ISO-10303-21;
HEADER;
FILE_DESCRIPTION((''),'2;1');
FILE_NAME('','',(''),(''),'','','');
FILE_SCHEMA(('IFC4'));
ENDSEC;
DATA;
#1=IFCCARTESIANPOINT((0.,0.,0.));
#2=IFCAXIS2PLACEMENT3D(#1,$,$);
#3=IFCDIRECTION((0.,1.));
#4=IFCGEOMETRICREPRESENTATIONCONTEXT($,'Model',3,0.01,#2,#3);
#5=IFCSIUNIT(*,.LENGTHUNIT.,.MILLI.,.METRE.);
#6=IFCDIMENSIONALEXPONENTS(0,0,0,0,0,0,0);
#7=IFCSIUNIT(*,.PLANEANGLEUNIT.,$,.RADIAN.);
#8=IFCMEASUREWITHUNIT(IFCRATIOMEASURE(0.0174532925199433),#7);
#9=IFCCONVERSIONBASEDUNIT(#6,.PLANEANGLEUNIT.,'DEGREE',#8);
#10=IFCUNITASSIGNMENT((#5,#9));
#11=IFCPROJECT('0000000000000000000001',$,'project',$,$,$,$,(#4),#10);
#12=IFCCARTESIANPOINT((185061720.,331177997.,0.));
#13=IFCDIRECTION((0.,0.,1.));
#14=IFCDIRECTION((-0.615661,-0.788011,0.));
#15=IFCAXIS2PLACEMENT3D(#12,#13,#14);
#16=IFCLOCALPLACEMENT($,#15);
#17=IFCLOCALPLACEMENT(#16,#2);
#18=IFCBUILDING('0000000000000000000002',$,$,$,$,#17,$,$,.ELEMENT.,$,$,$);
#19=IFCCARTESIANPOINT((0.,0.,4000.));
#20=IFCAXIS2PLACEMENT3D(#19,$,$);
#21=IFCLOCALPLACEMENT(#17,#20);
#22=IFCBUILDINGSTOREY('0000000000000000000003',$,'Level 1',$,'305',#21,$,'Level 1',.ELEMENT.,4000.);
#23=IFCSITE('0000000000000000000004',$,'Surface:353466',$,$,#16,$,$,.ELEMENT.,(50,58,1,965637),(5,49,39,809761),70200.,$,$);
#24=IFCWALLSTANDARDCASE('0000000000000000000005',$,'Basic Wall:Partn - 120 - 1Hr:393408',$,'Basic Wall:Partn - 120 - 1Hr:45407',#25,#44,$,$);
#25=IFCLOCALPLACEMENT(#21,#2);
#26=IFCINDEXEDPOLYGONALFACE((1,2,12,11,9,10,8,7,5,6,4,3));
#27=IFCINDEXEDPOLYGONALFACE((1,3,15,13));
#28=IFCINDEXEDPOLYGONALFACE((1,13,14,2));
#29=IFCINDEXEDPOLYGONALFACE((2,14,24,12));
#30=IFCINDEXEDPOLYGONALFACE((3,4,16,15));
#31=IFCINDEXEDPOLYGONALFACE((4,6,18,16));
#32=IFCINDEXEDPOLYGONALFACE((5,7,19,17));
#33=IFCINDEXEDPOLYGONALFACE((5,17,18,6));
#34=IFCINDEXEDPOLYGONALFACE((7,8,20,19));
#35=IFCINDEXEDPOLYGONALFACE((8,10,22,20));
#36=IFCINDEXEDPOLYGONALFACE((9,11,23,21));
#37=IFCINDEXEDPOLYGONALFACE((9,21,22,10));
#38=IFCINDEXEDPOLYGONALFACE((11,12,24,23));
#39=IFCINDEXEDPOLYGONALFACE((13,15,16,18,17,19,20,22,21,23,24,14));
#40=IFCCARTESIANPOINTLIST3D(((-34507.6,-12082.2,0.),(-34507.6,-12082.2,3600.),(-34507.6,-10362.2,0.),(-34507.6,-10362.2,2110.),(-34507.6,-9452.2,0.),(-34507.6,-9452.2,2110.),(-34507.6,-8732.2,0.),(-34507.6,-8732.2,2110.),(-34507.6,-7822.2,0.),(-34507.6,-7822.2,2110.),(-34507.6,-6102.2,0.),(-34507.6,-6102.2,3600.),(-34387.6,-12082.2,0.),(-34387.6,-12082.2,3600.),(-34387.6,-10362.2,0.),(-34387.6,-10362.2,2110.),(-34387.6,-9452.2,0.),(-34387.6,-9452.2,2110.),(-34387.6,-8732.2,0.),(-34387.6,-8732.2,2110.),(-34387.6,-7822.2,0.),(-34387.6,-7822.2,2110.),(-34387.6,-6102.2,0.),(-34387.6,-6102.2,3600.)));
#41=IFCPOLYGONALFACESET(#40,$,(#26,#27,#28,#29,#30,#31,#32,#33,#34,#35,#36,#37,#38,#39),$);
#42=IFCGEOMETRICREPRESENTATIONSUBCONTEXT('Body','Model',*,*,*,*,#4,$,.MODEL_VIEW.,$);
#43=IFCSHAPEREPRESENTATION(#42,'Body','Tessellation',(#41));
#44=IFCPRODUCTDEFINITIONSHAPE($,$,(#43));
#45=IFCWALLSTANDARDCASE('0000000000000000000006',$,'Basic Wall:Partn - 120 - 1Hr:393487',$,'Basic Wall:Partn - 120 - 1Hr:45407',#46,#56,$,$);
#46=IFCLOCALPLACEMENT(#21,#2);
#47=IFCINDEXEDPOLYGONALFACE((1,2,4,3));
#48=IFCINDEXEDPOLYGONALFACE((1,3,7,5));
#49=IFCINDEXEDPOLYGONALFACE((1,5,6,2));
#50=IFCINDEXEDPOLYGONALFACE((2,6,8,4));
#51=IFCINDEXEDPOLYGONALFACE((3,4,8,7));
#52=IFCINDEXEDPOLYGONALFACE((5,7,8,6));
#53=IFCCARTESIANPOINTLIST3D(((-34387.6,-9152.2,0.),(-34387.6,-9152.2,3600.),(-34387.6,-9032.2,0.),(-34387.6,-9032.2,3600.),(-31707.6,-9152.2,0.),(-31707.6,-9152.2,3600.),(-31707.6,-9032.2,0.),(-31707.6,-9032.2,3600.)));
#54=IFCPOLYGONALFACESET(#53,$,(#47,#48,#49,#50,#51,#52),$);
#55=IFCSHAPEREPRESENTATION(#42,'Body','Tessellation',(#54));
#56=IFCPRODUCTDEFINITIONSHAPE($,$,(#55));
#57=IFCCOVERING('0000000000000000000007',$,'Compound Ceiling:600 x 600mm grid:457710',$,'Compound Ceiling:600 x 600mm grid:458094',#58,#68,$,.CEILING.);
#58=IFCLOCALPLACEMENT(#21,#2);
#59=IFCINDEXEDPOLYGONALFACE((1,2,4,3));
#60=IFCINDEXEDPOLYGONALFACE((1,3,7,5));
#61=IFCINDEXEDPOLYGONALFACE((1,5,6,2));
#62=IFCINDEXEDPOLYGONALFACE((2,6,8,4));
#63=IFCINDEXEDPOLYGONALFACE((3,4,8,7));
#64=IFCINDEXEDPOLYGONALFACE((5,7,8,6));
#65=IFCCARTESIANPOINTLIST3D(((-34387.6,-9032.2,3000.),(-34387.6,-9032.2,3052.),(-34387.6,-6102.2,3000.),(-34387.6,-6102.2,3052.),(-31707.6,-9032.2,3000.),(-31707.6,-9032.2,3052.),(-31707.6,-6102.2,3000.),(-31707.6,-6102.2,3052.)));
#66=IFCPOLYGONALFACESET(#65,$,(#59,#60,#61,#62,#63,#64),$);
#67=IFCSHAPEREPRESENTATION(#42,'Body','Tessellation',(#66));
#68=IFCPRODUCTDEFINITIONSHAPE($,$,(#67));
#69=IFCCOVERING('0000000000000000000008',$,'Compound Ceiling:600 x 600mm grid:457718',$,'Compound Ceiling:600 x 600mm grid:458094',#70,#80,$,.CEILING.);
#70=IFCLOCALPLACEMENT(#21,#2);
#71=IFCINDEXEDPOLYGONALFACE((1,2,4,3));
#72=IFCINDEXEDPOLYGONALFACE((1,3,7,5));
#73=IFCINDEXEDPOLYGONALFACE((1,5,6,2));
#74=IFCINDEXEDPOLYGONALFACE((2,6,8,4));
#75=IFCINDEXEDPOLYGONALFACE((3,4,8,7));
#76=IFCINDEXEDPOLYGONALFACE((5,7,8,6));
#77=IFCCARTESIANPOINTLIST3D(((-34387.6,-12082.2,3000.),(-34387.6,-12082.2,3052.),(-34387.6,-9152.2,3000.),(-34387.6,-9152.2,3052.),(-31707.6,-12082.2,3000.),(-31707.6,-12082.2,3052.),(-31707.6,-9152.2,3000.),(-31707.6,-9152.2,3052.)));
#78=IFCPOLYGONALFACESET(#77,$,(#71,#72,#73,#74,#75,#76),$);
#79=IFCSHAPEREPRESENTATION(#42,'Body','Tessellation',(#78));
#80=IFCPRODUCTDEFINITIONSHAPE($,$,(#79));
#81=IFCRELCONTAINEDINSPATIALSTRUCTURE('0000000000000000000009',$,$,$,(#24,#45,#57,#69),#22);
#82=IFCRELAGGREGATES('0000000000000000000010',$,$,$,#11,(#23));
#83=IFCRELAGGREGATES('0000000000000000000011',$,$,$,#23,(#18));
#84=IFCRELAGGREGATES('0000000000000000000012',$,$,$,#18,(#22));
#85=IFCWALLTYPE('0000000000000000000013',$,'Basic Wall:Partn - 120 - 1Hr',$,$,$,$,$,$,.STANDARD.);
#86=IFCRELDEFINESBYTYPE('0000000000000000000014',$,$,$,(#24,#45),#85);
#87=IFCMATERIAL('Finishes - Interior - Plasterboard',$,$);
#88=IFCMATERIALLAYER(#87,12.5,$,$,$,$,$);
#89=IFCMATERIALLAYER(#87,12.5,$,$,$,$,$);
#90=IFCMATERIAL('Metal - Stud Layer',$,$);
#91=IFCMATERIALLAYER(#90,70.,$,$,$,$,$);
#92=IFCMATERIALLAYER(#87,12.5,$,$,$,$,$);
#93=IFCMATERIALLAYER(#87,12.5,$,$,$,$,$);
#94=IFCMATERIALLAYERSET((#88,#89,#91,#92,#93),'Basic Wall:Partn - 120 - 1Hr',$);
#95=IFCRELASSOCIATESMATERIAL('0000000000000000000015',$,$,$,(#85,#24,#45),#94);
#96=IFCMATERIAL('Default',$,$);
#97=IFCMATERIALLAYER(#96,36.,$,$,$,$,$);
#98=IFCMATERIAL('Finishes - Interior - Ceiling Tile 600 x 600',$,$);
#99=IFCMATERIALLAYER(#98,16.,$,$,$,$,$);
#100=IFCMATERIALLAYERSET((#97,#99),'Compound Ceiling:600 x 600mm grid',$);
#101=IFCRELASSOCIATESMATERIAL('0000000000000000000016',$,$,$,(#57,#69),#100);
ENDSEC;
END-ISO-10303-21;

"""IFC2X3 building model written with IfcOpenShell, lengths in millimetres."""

from ifc_helpers import new_model, entity, si_unit, converted_unit, direction, frame, frame_2d, origin, place, context, subcontext, project, spatial, polyline, rectangle, extrude, clip, bounded_halfspace, material, layer, layer_set, layer_usage, type_object, element, save


model = new_model("IFC2X3")

# Units and contexts
model_context = context("Model", 3, precision=0.01, world=origin(), true_north=direction((0.0, 1.0)))
body_context = subcontext(model_context, "Body", "Model", "MODEL_VIEW")
ifc_project = project(units=[si_unit("LENGTHUNIT", "METRE", prefix="MILLI"), converted_unit("PLANEANGLEUNIT", "DEGREE", entity("IfcRatioMeasure", 0.0174532925199433), si_unit("PLANEANGLEUNIT", "RADIAN"), dimensions=[0, 0, 0, 0, 0, 0, 0])], contexts=[model_context])

# Site, building, storey
site_placement = place(None, frame((185061720.0, 331177997.0, 0.0), z_axis=(0.0, 0.0, 1.0), x_axis=(-0.615661, -0.788011, 0.0)))
site = spatial("IfcSite", under=ifc_project, at=site_placement, Name="Surface:353466", CompositionType="ELEMENT", RefLatitude=(50, 58, 1, 965637), RefLongitude=(5, 49, 39, 809761), RefElevation=70200.0)
building_placement = place(site_placement, origin())
building = spatial("IfcBuilding", under=site, at=building_placement, CompositionType="ELEMENT")
storey_placement = place(building_placement, frame((0.0, 0.0, 4000.0)))
storey = spatial("IfcBuildingStorey", under=building, at=storey_placement, Name="Level 1", ObjectType="305", LongName="Level 1", CompositionType="ELEMENT", Elevation=4000.0)

# Shared definitions
ifc_material_1 = material(Name="Finishes - Interior - Plasterboard")

# Shared definitions
ifc_layer_1 = layer(ifc_material_1, 12.5)
ifc_layer_2 = layer(ifc_material_1, 12.5)
ifc_material_2 = material(Name="Metal - Stud Layer")
ifc_layer_3 = layer(ifc_material_2, 70.0)
ifc_layer_4 = layer(ifc_material_1, 12.5)
ifc_layer_5 = layer(ifc_material_1, 12.5)
ifc_layer_set_1 = layer_set([ifc_layer_1, ifc_layer_2, ifc_layer_3, ifc_layer_4, ifc_layer_5], Name="Basic Wall:Partn - 120 - 1Hr")
wall_type_1 = type_object("IfcWallType", Name="Basic Wall:Partn - 120 - 1Hr", PredefinedType="STANDARD", material=ifc_layer_set_1)

# Wall, openings
ifc_layer_usage_1 = layer_usage(ifc_layer_set_1, "AXIS2", "NEGATIVE", 60.0)
wall_1_placement = place(storey_placement, frame((-34447.6, -12082.2, 0.0), z_axis=(0.0, 0.0, 1.0), x_axis=(0.0, 1.0, 0.0)))
wall_1 = element("IfcWallStandardCase", 1, at=wall_1_placement, inside=storey, type_object=wall_type_1, material=ifc_layer_usage_1, Name="Basic Wall:Partn - 120 - 1Hr:393408", ObjectType="Basic Wall:Partn - 120 - 1Hr:45407", context=body_context, shape_type="Clipping", body=[
    clip(extrude(rectangle(XDim=5980.0, YDim=120.0, at=frame_2d((2990.0, 0.0), x_axis=(-1.0, 0.0))), origin(), (0.0, 0.0, 1.0), 3600.0), bounded_halfspace(frame((0.0, -60.0, 3600.0), z_axis=(0.0, 0.0, -1.0), x_axis=(0.0, -1.0, 0.0)), True, frame((0.0, -60.0, 3600.0)), polyline([(0.0, 0.0), (2930.0, 0.0), (3050.0, 0.0), (5980.0, 0.0), (5980.0, 120.0), (0.0, 120.0), (0.0, 0.0)]))),
])
opening_1_placement = place(wall_1_placement, frame((3350.0, 1584.0, 0.0)))
element("IfcOpeningElement", 2, at=opening_1_placement, cuts=wall_1, ObjectType="Opening", context=body_context, shape_type="SweptSolid", body=[
    extrude(rectangle(XDim=2110.0, YDim=910.0, at=frame_2d((0.0, 0.0), x_axis=(1.0, 0.0))), frame((455.0, -3048.0, 1055.0), z_axis=(0.0, 1.0, 0.0), x_axis=(0.0, 0.0, 1.0)), (0.0, 0.0, 1.0), 3048.0),
])
opening_2_placement = place(wall_1_placement, frame((1720.0, 1584.0, 0.0)))
element("IfcOpeningElement", 3, at=opening_2_placement, cuts=wall_1, ObjectType="Opening", context=body_context, shape_type="SweptSolid", body=[
    extrude(rectangle(XDim=2110.0, YDim=910.0, at=frame_2d((0.0, 0.0), x_axis=(0.0, 1.0))), frame((455.0, -3048.0, 1055.0), z_axis=(0.0, 1.0, 0.0), x_axis=(-1.0, 0.0, 0.0)), (0.0, 0.0, 1.0), 3048.0),
])
opening_3_placement = place(wall_1_placement, frame((4260.0, 60.0, 0.0)))
element("IfcOpeningElement", 4, at=opening_3_placement, cuts=wall_1, ObjectType="Opening", context=body_context, shape_type="SweptSolid", body=[
    extrude(rectangle(XDim=2110.0, YDim=910.0, at=frame_2d((1055.0, 455.0), x_axis=(1.0, 0.0))), frame((0.0, 0.0, 0.0), z_axis=(0.0, -1.0, 0.0), x_axis=(0.0, 0.0, 1.0)), (0.0, 0.0, 1.0), 120.0),
])
opening_4_placement = place(wall_1_placement, frame((2630.0, 60.0, 0.0)))
element("IfcOpeningElement", 5, at=opening_4_placement, cuts=wall_1, ObjectType="Opening", context=body_context, shape_type="SweptSolid", body=[
    extrude(rectangle(XDim=2110.0, YDim=910.0, at=frame_2d((1055.0, 455.0), x_axis=(1.0, 0.0))), frame((0.0, 0.0, 0.0), z_axis=(0.0, -1.0, 0.0), x_axis=(0.0, 0.0, 1.0)), (0.0, 0.0, 1.0), 120.0),
])

# Wall
ifc_layer_usage_2 = layer_usage(ifc_layer_set_1, "AXIS2", "NEGATIVE", 60.0)
wall_2_placement = place(storey_placement, frame((-34387.6, -9092.2, 0.0)))
element("IfcWallStandardCase", 6, at=wall_2_placement, inside=storey, type_object=wall_type_1, material=ifc_layer_usage_2, Name="Basic Wall:Partn - 120 - 1Hr:393487", ObjectType="Basic Wall:Partn - 120 - 1Hr:45407", context=body_context, shape_type="Clipping", body=[
    clip(extrude(rectangle(XDim=2680.0, YDim=120.0, at=frame_2d((1340.0, 0.0), x_axis=(-1.0, 0.0))), origin(), (0.0, 0.0, 1.0), 3600.0), bounded_halfspace(frame((0.0, -60.0, 3600.0), z_axis=(0.0, 0.0, -1.0), x_axis=(1.0, 0.0, 0.0)), True, frame((0.0, -60.0, 3600.0)), polyline([(0.0, 0.0), (2680.0, 0.0), (2680.0, 120.0), (0.0, 120.0), (0.0, 0.0)]))),
])

# Coverings
ifc_material_3 = material(Name="Default")
ifc_layer_6 = layer(ifc_material_3, 36.0)
ifc_material_4 = material(Name="Finishes - Interior - Ceiling Tile 600 x 600")
ifc_layer_7 = layer(ifc_material_4, 16.0)
ifc_layer_set_2 = layer_set([ifc_layer_6, ifc_layer_7], Name="Compound Ceiling:600 x 600mm grid")
ifc_layer_usage_3 = layer_usage(ifc_layer_set_2, "AXIS3", "POSITIVE", 0.0)
covering_1_placement = place(storey_placement, frame((-34387.6, -9032.2, 3000.0)))
element("IfcCovering", 7, at=covering_1_placement, inside=storey, material=ifc_layer_usage_3, Name="Compound Ceiling:600 x 600mm grid:457710", ObjectType="Compound Ceiling:600 x 600mm grid:458094", PredefinedType="CEILING", context=body_context, shape_type="SweptSolid", body=[
    extrude(rectangle(XDim=2930.0, YDim=2680.0, at=frame_2d((0.0, 0.0), x_axis=(1.0, 0.0))), frame((1340.0, 1465.0, 0.0), z_axis=(0.0, 0.0, 1.0), x_axis=(0.0, -1.0, 0.0)), (0.0, 0.0, 1.0), 52.0),
])
ifc_layer_usage_4 = layer_usage(ifc_layer_set_2, "AXIS3", "POSITIVE", 0.0)
covering_2_placement = place(storey_placement, frame((-34387.6, -12082.2, 3000.0)))
element("IfcCovering", 8, at=covering_2_placement, inside=storey, material=ifc_layer_usage_4, Name="Compound Ceiling:600 x 600mm grid:457718", ObjectType="Compound Ceiling:600 x 600mm grid:458094", PredefinedType="CEILING", context=body_context, shape_type="SweptSolid", body=[
    extrude(rectangle(XDim=2680.0, YDim=2930.0, at=frame_2d((0.0, 0.0), x_axis=(1.0, 0.0))), frame((1340.0, 1465.0, 0.0), z_axis=(0.0, 0.0, 1.0), x_axis=(-1.0, 0.0, 0.0)), (0.0, 0.0, 1.0), 52.0),
])

save(model, "model.ifc")
